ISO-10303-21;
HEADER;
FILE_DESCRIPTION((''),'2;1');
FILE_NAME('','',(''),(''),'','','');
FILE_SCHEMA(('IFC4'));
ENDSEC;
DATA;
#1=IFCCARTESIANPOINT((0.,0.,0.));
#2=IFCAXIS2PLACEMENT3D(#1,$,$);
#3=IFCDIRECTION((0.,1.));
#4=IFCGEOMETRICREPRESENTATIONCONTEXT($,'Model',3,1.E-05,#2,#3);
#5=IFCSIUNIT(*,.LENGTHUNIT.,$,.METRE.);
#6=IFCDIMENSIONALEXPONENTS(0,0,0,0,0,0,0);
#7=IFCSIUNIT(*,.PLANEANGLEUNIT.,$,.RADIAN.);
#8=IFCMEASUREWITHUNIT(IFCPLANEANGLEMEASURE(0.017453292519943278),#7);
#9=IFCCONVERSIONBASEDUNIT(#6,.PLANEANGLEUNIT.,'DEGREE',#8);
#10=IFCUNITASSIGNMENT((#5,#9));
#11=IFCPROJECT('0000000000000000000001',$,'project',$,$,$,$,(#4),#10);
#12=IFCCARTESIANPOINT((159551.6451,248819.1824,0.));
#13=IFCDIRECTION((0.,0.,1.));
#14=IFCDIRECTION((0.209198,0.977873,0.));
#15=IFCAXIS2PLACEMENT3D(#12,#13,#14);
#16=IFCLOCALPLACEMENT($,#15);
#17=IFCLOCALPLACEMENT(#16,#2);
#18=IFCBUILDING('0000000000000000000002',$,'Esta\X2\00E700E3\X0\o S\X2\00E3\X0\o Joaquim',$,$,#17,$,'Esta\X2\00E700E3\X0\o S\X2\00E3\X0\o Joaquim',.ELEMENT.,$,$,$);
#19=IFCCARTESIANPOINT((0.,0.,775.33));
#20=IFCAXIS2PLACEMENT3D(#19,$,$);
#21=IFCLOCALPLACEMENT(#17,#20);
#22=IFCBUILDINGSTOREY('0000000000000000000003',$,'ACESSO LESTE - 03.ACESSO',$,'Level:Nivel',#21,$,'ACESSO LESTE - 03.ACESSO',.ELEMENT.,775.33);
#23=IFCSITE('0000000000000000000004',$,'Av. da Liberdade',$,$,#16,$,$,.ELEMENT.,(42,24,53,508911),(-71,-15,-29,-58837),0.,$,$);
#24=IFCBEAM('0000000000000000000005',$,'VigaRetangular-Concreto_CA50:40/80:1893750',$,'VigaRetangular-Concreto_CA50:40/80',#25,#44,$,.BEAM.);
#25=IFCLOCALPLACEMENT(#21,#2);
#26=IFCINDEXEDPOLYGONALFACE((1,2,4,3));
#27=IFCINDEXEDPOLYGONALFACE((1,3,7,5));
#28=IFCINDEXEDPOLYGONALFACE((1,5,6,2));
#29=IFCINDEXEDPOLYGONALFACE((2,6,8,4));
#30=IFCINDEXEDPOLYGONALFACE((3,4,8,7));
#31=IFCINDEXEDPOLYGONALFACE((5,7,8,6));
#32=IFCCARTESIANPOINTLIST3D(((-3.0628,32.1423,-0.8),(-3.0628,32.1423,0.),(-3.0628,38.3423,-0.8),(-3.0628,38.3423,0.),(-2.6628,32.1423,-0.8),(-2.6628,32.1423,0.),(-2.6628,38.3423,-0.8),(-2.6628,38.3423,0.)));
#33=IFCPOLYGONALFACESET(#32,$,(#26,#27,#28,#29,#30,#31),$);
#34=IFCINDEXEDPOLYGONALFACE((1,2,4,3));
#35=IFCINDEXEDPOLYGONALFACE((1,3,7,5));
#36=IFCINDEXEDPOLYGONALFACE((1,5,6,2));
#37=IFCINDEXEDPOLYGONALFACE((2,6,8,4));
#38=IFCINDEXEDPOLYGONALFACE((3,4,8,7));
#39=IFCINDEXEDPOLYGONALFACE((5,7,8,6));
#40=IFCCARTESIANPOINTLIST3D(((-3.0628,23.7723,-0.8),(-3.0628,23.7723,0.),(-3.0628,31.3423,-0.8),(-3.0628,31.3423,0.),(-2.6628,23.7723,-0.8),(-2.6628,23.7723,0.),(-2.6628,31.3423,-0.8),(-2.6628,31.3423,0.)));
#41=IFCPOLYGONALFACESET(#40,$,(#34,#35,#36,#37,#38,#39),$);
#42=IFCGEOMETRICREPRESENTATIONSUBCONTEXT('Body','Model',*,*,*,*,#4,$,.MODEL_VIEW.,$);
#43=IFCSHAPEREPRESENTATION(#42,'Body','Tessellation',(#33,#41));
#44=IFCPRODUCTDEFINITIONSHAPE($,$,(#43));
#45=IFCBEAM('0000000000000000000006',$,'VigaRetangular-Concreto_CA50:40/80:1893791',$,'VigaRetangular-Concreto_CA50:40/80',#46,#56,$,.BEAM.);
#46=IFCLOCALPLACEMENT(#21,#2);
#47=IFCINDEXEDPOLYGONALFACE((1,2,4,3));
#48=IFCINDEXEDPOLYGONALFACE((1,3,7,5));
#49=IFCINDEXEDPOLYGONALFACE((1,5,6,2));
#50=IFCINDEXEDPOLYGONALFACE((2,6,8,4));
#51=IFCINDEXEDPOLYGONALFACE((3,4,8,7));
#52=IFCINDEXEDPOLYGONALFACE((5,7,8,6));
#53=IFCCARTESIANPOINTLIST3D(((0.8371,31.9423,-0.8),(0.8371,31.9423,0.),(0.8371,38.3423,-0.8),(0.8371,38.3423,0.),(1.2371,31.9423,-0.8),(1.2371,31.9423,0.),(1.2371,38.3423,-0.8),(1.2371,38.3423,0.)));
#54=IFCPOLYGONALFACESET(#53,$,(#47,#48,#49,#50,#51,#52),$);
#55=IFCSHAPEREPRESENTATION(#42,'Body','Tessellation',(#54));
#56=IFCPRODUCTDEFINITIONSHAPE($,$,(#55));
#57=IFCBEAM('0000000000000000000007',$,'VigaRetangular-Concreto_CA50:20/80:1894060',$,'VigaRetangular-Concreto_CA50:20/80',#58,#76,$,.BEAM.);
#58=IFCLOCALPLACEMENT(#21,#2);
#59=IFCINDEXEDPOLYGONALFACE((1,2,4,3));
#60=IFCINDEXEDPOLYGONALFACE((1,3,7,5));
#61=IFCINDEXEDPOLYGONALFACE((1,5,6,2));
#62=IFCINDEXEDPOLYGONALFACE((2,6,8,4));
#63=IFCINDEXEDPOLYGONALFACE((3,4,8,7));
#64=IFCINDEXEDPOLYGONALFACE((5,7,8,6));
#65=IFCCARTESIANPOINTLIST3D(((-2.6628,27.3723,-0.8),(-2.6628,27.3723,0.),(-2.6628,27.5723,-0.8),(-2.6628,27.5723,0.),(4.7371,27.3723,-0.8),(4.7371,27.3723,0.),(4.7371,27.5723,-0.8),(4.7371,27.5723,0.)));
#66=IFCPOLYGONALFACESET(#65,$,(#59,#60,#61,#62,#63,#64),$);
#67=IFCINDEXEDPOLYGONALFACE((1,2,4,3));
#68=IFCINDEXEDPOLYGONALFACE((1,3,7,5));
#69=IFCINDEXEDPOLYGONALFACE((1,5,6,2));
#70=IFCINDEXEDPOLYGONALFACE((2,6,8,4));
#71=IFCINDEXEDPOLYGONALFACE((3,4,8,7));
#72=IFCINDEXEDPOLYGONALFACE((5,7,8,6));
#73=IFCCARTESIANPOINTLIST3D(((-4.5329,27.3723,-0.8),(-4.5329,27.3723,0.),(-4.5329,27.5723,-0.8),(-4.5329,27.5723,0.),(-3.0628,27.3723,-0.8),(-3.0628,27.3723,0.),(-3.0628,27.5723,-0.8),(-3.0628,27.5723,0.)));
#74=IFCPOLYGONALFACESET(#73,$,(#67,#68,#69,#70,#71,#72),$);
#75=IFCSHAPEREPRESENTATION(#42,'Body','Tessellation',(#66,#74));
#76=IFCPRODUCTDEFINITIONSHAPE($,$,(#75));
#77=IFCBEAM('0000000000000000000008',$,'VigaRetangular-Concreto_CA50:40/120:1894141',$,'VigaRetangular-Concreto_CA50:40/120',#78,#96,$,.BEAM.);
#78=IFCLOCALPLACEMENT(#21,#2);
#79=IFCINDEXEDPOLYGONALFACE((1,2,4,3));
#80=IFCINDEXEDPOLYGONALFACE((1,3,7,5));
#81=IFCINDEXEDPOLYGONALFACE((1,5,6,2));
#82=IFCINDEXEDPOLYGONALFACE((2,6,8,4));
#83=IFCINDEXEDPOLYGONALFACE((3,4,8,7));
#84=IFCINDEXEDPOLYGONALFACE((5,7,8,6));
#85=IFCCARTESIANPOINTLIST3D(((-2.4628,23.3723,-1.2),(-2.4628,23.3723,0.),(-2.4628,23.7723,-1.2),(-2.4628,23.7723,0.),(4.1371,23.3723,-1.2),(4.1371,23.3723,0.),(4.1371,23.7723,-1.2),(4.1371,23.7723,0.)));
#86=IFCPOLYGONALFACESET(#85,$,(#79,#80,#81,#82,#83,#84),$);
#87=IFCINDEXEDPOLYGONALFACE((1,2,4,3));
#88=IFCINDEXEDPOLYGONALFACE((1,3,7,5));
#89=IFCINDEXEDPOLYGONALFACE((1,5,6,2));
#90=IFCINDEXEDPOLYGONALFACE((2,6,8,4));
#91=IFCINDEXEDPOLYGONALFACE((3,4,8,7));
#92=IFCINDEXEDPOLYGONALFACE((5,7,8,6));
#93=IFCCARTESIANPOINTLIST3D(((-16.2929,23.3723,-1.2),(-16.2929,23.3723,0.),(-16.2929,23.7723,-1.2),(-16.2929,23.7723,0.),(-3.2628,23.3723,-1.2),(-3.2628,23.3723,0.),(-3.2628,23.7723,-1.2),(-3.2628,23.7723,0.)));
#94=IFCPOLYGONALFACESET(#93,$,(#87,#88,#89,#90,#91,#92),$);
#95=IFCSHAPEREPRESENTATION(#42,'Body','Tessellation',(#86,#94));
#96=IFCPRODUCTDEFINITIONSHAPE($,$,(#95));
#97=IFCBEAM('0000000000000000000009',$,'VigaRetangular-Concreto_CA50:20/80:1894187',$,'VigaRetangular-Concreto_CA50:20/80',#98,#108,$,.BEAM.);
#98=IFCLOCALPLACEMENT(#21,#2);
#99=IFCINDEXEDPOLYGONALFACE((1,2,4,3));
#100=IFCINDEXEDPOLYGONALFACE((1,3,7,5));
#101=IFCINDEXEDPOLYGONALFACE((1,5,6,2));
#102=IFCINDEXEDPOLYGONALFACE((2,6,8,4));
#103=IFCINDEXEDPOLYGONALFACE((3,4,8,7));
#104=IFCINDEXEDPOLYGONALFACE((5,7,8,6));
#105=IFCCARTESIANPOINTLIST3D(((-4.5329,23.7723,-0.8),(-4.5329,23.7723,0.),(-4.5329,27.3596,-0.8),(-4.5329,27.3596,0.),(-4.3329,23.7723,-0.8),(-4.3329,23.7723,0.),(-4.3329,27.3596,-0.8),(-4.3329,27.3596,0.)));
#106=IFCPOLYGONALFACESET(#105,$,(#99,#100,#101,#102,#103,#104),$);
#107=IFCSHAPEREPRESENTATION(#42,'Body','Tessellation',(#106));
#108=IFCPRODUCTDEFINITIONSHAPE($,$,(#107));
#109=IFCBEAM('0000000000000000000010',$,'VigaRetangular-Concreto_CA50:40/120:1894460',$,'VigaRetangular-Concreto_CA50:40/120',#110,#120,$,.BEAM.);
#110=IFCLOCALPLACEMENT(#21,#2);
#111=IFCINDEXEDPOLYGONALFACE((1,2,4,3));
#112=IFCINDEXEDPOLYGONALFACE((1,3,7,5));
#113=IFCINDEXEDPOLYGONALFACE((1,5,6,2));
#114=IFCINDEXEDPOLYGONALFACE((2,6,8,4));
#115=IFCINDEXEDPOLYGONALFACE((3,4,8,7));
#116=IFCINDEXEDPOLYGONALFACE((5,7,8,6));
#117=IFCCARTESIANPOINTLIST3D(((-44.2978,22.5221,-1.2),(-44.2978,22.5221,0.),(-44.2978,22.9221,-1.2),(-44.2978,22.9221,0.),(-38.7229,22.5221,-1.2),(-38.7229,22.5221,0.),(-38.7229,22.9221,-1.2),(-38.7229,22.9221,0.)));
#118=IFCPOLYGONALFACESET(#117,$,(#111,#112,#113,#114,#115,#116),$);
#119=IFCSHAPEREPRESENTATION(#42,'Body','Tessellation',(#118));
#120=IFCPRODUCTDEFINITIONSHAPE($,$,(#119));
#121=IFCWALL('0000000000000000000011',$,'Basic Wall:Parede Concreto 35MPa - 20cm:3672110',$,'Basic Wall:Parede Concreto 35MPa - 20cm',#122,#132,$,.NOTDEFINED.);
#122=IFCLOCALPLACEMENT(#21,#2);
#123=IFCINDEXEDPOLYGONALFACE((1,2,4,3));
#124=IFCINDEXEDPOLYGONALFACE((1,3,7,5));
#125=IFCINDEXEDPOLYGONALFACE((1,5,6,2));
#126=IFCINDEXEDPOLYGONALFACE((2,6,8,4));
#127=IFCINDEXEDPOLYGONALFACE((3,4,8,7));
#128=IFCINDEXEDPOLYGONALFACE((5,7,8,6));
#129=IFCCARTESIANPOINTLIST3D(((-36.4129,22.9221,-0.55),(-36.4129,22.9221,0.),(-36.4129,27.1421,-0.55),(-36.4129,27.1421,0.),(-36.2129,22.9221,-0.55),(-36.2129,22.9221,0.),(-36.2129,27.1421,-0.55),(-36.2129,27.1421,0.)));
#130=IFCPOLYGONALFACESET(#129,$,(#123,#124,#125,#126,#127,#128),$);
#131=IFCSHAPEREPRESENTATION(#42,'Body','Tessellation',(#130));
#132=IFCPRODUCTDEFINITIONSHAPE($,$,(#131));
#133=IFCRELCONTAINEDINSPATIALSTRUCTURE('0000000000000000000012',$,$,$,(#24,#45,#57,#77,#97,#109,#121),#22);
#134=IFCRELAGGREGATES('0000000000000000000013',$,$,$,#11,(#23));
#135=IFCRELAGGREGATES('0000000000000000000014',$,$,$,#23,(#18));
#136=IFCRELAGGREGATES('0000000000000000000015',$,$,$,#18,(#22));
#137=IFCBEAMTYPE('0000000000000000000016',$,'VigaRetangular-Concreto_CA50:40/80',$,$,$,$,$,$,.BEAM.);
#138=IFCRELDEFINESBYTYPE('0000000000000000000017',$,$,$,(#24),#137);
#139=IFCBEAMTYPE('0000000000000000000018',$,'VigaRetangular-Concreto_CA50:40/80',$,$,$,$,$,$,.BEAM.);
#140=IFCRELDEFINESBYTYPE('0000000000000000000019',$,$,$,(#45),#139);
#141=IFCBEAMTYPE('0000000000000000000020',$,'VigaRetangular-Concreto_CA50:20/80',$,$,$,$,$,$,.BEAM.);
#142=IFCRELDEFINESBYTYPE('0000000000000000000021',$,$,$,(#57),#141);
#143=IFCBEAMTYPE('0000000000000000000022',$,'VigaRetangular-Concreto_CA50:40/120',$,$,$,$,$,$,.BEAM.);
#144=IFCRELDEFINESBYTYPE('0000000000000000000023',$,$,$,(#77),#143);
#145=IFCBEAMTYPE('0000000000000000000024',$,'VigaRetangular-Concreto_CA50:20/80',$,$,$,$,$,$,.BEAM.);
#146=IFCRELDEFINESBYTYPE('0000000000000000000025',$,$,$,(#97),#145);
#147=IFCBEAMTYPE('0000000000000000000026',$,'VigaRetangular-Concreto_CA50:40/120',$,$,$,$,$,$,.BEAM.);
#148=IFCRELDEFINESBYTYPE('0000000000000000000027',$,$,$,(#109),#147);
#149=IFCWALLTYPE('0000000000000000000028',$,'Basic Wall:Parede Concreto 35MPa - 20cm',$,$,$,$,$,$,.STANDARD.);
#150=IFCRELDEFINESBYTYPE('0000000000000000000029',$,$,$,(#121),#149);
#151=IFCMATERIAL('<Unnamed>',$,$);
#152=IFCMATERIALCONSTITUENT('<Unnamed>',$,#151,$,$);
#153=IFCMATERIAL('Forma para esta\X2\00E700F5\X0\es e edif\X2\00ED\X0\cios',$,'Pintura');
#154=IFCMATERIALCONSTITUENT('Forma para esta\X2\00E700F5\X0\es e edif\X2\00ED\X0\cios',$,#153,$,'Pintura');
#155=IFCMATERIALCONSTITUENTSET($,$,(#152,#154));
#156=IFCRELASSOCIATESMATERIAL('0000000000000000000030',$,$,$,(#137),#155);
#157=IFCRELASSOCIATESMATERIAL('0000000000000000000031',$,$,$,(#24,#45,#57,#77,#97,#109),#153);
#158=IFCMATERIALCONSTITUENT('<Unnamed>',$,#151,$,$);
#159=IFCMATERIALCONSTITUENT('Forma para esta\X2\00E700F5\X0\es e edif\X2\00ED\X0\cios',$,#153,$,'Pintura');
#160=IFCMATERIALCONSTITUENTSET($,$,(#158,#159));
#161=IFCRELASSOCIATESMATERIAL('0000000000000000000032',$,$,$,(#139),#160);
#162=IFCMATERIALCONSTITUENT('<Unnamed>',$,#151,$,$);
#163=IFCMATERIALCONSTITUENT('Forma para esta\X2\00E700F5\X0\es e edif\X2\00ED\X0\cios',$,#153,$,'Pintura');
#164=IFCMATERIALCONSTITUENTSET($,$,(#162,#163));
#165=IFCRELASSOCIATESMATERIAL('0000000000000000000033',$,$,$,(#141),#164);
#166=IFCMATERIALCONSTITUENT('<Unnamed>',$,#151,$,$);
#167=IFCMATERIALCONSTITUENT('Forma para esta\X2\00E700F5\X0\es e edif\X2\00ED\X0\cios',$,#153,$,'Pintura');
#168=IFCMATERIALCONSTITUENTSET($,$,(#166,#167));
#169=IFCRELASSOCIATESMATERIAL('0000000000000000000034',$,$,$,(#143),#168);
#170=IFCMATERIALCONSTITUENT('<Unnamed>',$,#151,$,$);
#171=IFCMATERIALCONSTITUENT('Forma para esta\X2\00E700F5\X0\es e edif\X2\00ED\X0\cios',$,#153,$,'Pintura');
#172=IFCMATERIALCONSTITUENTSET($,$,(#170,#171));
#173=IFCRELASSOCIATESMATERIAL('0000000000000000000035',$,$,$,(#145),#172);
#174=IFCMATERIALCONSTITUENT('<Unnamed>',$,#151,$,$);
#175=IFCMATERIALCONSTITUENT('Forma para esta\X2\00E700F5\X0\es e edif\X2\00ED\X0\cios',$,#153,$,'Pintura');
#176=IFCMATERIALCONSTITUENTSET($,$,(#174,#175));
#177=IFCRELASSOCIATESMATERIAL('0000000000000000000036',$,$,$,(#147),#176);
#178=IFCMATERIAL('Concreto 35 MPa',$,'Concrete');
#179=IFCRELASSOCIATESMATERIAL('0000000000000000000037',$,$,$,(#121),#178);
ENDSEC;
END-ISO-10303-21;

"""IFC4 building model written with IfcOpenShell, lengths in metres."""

from ifc_helpers import new_model, entity, si_unit, converted_unit, direction, frame, origin, place, context, subcontext, project, spatial, indexed_curve, outline, extrude, source, transform, mapped, material, constituent, constituent_set, type_object, type_shapes, element, save


model = new_model("IFC4")

# Units and contexts
model_context = context("Model", 3, precision=1e-05, world=origin(), true_north=direction((0.0, 1.0)))
body_context = subcontext(model_context, "Body", "Model", "MODEL_VIEW")
ifc_project = project(units=[si_unit("LENGTHUNIT", "METRE"), converted_unit("PLANEANGLEUNIT", "DEGREE", entity("IfcPlaneAngleMeasure", 0.017453292519943278), si_unit("PLANEANGLEUNIT", "RADIAN"), dimensions=[0, 0, 0, 0, 0, 0, 0])], contexts=[model_context])

# Site, building, storey
site_placement = place(None, frame((159551.6451, 248819.1824, 0.0), z_axis=(0.0, 0.0, 1.0), x_axis=(0.209198, 0.977873, 0.0)))
site = spatial("IfcSite", under=ifc_project, at=site_placement, Name="Av. da Liberdade", CompositionType="ELEMENT", RefLatitude=(42, 24, 53, 508911), RefLongitude=(-71, -15, -29, -58837), RefElevation=0.0)
building_placement = place(site_placement, origin())
building = spatial("IfcBuilding", under=site, at=building_placement, Name="Estação São Joaquim", LongName="Estação São Joaquim", CompositionType="ELEMENT")
storey_placement = place(building_placement, frame((0.0, 0.0, 775.33)))
storey = spatial("IfcBuildingStorey", under=building, at=storey_placement, Name="ACESSO LESTE - 03.ACESSO", ObjectType="Level:Nivel", LongName="ACESSO LESTE - 03.ACESSO", CompositionType="ELEMENT", Elevation=775.33)

# Shared definitions
ifc_material_1 = material(Name="Forma para estações e edifícios", Category="Pintura")

# Beams
ifc_material_2 = material(Name="<Unnamed>")
ifc_constituent_1 = constituent(ifc_material_2, Name="<Unnamed>")
ifc_constituent_2 = constituent(ifc_material_1, Name="Forma para estações e edifícios", Category="Pintura")
ifc_constituent_set_1 = constituent_set(constituents=[ifc_constituent_1, ifc_constituent_2])
beam_type_1 = type_object("IfcBeamType", Name="VigaRetangular-Concreto_CA50:40/80", PredefinedType="BEAM", material=ifc_constituent_set_1)
shared_shape_1 = source(origin(), body_context, "Body", "SweptSolid", [
    extrude(outline(indexed_curve([(-0.2, -0.4), (0.2, -0.4), (0.2, 0.4), (-0.2, 0.4), (-0.2, -0.4)], self_intersect=False)), frame((-2.8628, 32.1423, 774.93), z_axis=(0.0, 1.0, 0.0), x_axis=(-1.0, 0.0, 0.0)), (0.0, 0.0, 1.0), 6.2),
    extrude(outline(indexed_curve([(-0.2, -0.4), (0.2, -0.4), (0.2, 0.4), (-0.2, 0.4), (-0.2, -0.4)], self_intersect=False)), frame((-2.8628, 23.7723, 774.93), z_axis=(0.0, 1.0, 0.0), x_axis=(-1.0, 0.0, 0.0)), (0.0, 0.0, 1.0), 7.57),
])
type_shapes(beam_type_1, [shared_shape_1])
beam_1_placement = place(storey_placement, frame((0.0, 0.0, -775.33)))
element("IfcBeam", 1, at=beam_1_placement, inside=storey, type_object=beam_type_1, material=ifc_material_1, Name="VigaRetangular-Concreto_CA50:40/80:1893750", ObjectType="VigaRetangular-Concreto_CA50:40/80", PredefinedType="BEAM", context=body_context, shape_type="MappedRepresentation", body=[
    mapped(shared_shape_1, transform((0.0, 0.0, 0.0), scale=1.0)),
])
ifc_constituent_3 = constituent(ifc_material_2, Name="<Unnamed>")
ifc_constituent_4 = constituent(ifc_material_1, Name="Forma para estações e edifícios", Category="Pintura")
ifc_constituent_set_2 = constituent_set(constituents=[ifc_constituent_3, ifc_constituent_4])
beam_type_2 = type_object("IfcBeamType", Name="VigaRetangular-Concreto_CA50:40/80", PredefinedType="BEAM", material=ifc_constituent_set_2)
shared_shape_2 = source(origin(), body_context, "Body", "SweptSolid", [
    extrude(outline(indexed_curve([(-0.2, -0.4), (0.2, -0.4), (0.2, 0.4), (-0.2, 0.4), (-0.2, -0.4)], self_intersect=False)), frame((1.0371, 31.9423, 774.93), z_axis=(0.0, 1.0, 0.0), x_axis=(-1.0, 0.0, 0.0)), (0.0, 0.0, 1.0), 6.4),
])
type_shapes(beam_type_2, [shared_shape_2])
beam_2_placement = place(storey_placement, frame((0.0, 0.0, -775.33)))
element("IfcBeam", 2, at=beam_2_placement, inside=storey, type_object=beam_type_2, material=ifc_material_1, Name="VigaRetangular-Concreto_CA50:40/80:1893791", ObjectType="VigaRetangular-Concreto_CA50:40/80", PredefinedType="BEAM", context=body_context, shape_type="MappedRepresentation", body=[
    mapped(shared_shape_2, transform((0.0, 0.0, 0.0), scale=1.0)),
])
ifc_constituent_5 = constituent(ifc_material_2, Name="<Unnamed>")
ifc_constituent_6 = constituent(ifc_material_1, Name="Forma para estações e edifícios", Category="Pintura")
ifc_constituent_set_3 = constituent_set(constituents=[ifc_constituent_5, ifc_constituent_6])
beam_type_3 = type_object("IfcBeamType", Name="VigaRetangular-Concreto_CA50:20/80", PredefinedType="BEAM", material=ifc_constituent_set_3)
shared_shape_3 = source(origin(), body_context, "Body", "SweptSolid", [
    extrude(outline(indexed_curve([(-0.4, -0.1), (0.4, -0.1), (0.4, 0.1), (-0.4, 0.1), (-0.4, -0.1)], self_intersect=False)), frame((4.7371, 27.4723, 774.93), z_axis=(-1.0, 0.0, 0.0), x_axis=(0.0, 0.0, -1.0)), (0.0, 0.0, 1.0), 7.3999),
    extrude(outline(indexed_curve([(-0.4, -0.1), (0.4, -0.1), (0.4, 0.1), (-0.4, 0.1), (-0.4, -0.1)], self_intersect=False)), frame((-3.0628, 27.4723, 774.93), z_axis=(-1.0, 0.0, 0.0), x_axis=(0.0, 0.0, -1.0)), (0.0, 0.0, 1.0), 1.4701),
])
type_shapes(beam_type_3, [shared_shape_3])
beam_3_placement = place(storey_placement, frame((0.0, 0.0, -775.33)))
element("IfcBeam", 3, at=beam_3_placement, inside=storey, type_object=beam_type_3, material=ifc_material_1, Name="VigaRetangular-Concreto_CA50:20/80:1894060", ObjectType="VigaRetangular-Concreto_CA50:20/80", PredefinedType="BEAM", context=body_context, shape_type="MappedRepresentation", body=[
    mapped(shared_shape_3, transform((0.0, 0.0, 0.0), scale=1.0)),
])
ifc_constituent_7 = constituent(ifc_material_2, Name="<Unnamed>")
ifc_constituent_8 = constituent(ifc_material_1, Name="Forma para estações e edifícios", Category="Pintura")
ifc_constituent_set_4 = constituent_set(constituents=[ifc_constituent_7, ifc_constituent_8])
beam_type_4 = type_object("IfcBeamType", Name="VigaRetangular-Concreto_CA50:40/120", PredefinedType="BEAM", material=ifc_constituent_set_4)
shared_shape_4 = source(origin(), body_context, "Body", "SweptSolid", [
    extrude(outline(indexed_curve([(-0.6, -0.2), (0.6, -0.2), (0.6, 0.2), (-0.6, 0.2), (-0.6, -0.2)], self_intersect=False)), frame((-2.4628, 23.5723, 774.73), z_axis=(1.0, 0.0, 0.0), x_axis=(0.0, 0.0, -1.0)), (0.0, 0.0, 1.0), 6.5999),
    extrude(outline(indexed_curve([(-0.6, -0.2), (0.6, -0.2), (0.6, 0.2), (-0.6, 0.2), (-0.6, -0.2)], self_intersect=False)), frame((-16.2929, 23.5723, 774.73), z_axis=(1.0, 0.0, 0.0), x_axis=(0.0, 0.0, -1.0)), (0.0, 0.0, 1.0), 13.0301),
])
type_shapes(beam_type_4, [shared_shape_4])
beam_4_placement = place(storey_placement, frame((0.0, 0.0, -775.33)))
element("IfcBeam", 4, at=beam_4_placement, inside=storey, type_object=beam_type_4, material=ifc_material_1, Name="VigaRetangular-Concreto_CA50:40/120:1894141", ObjectType="VigaRetangular-Concreto_CA50:40/120", PredefinedType="BEAM", context=body_context, shape_type="MappedRepresentation", body=[
    mapped(shared_shape_4, transform((0.0, 0.0, 0.0), scale=1.0)),
])
ifc_constituent_9 = constituent(ifc_material_2, Name="<Unnamed>")
ifc_constituent_10 = constituent(ifc_material_1, Name="Forma para estações e edifícios", Category="Pintura")
ifc_constituent_set_5 = constituent_set(constituents=[ifc_constituent_9, ifc_constituent_10])
beam_type_5 = type_object("IfcBeamType", Name="VigaRetangular-Concreto_CA50:20/80", PredefinedType="BEAM", material=ifc_constituent_set_5)
shared_shape_5 = source(origin(), body_context, "Body", "SweptSolid", [
    extrude(outline(indexed_curve([(-0.1, -0.4), (0.1, -0.4), (0.1, 0.4), (-0.1, 0.4), (-0.1, -0.4)], self_intersect=False)), frame((-4.4329, 27.3596, 774.93), z_axis=(0.0, -1.0, 0.0), x_axis=(-1.0, 0.0, 0.0)), (0.0, 0.0, 1.0), 3.5873),
])
type_shapes(beam_type_5, [shared_shape_5])
beam_5_placement = place(storey_placement, frame((0.0, 0.0, -775.33)))
element("IfcBeam", 5, at=beam_5_placement, inside=storey, type_object=beam_type_5, material=ifc_material_1, Name="VigaRetangular-Concreto_CA50:20/80:1894187", ObjectType="VigaRetangular-Concreto_CA50:20/80", PredefinedType="BEAM", context=body_context, shape_type="MappedRepresentation", body=[
    mapped(shared_shape_5, transform((0.0, 0.0, 0.0), scale=1.0)),
])
ifc_constituent_11 = constituent(ifc_material_2, Name="<Unnamed>")
ifc_constituent_12 = constituent(ifc_material_1, Name="Forma para estações e edifícios", Category="Pintura")
ifc_constituent_set_6 = constituent_set(constituents=[ifc_constituent_11, ifc_constituent_12])
beam_type_6 = type_object("IfcBeamType", Name="VigaRetangular-Concreto_CA50:40/120", PredefinedType="BEAM", material=ifc_constituent_set_6)
shared_shape_6 = source(origin(), body_context, "Body", "SweptSolid", [
    extrude(outline(indexed_curve([(-0.6, -0.2), (0.6, -0.2), (0.6, 0.2), (-0.6, 0.2), (-0.6, -0.2)], self_intersect=False)), frame((-38.7229, 22.7221, 774.73), z_axis=(-1.0, 0.0, 0.0), x_axis=(0.0, 0.0, -1.0)), (0.0, 0.0, 1.0), 5.575),
])
type_shapes(beam_type_6, [shared_shape_6])
beam_6_placement = place(storey_placement, frame((0.0, 0.0, -775.33)))
element("IfcBeam", 6, at=beam_6_placement, inside=storey, type_object=beam_type_6, material=ifc_material_1, Name="VigaRetangular-Concreto_CA50:40/120:1894460", ObjectType="VigaRetangular-Concreto_CA50:40/120", PredefinedType="BEAM", context=body_context, shape_type="MappedRepresentation", body=[
    mapped(shared_shape_6, transform((0.0, 0.0, 0.0), scale=1.0)),
])

# Shared definitions
ifc_material_3 = material(Name="Concreto 35 MPa", Category="Concrete")

# Wall
wall_type = type_object("IfcWallType", Name="Basic Wall:Parede Concreto 35MPa - 20cm", PredefinedType="STANDARD")
wall_placement = place(storey_placement, frame((-36.3129, 27.1421, -0.55), z_axis=(0.0, 0.0, 1.0), x_axis=(0.0, -1.0, 0.0)))
element("IfcWall", 7, at=wall_placement, inside=storey, type_object=wall_type, material=ifc_material_3, Name="Basic Wall:Parede Concreto 35MPa - 20cm:3672110", ObjectType="Basic Wall:Parede Concreto 35MPa - 20cm", PredefinedType="NOTDEFINED", context=body_context, shape_type="SweptSolid", body=[
    extrude(outline(indexed_curve([(4.2201, 0.1), (0.0, 0.1), (0.0, -0.1), (4.2201, -0.1), (4.2201, 0.1)], self_intersect=False)), origin(), (0.0, 0.0, 1.0), 0.55),
])

save(model, "model.ifc")
